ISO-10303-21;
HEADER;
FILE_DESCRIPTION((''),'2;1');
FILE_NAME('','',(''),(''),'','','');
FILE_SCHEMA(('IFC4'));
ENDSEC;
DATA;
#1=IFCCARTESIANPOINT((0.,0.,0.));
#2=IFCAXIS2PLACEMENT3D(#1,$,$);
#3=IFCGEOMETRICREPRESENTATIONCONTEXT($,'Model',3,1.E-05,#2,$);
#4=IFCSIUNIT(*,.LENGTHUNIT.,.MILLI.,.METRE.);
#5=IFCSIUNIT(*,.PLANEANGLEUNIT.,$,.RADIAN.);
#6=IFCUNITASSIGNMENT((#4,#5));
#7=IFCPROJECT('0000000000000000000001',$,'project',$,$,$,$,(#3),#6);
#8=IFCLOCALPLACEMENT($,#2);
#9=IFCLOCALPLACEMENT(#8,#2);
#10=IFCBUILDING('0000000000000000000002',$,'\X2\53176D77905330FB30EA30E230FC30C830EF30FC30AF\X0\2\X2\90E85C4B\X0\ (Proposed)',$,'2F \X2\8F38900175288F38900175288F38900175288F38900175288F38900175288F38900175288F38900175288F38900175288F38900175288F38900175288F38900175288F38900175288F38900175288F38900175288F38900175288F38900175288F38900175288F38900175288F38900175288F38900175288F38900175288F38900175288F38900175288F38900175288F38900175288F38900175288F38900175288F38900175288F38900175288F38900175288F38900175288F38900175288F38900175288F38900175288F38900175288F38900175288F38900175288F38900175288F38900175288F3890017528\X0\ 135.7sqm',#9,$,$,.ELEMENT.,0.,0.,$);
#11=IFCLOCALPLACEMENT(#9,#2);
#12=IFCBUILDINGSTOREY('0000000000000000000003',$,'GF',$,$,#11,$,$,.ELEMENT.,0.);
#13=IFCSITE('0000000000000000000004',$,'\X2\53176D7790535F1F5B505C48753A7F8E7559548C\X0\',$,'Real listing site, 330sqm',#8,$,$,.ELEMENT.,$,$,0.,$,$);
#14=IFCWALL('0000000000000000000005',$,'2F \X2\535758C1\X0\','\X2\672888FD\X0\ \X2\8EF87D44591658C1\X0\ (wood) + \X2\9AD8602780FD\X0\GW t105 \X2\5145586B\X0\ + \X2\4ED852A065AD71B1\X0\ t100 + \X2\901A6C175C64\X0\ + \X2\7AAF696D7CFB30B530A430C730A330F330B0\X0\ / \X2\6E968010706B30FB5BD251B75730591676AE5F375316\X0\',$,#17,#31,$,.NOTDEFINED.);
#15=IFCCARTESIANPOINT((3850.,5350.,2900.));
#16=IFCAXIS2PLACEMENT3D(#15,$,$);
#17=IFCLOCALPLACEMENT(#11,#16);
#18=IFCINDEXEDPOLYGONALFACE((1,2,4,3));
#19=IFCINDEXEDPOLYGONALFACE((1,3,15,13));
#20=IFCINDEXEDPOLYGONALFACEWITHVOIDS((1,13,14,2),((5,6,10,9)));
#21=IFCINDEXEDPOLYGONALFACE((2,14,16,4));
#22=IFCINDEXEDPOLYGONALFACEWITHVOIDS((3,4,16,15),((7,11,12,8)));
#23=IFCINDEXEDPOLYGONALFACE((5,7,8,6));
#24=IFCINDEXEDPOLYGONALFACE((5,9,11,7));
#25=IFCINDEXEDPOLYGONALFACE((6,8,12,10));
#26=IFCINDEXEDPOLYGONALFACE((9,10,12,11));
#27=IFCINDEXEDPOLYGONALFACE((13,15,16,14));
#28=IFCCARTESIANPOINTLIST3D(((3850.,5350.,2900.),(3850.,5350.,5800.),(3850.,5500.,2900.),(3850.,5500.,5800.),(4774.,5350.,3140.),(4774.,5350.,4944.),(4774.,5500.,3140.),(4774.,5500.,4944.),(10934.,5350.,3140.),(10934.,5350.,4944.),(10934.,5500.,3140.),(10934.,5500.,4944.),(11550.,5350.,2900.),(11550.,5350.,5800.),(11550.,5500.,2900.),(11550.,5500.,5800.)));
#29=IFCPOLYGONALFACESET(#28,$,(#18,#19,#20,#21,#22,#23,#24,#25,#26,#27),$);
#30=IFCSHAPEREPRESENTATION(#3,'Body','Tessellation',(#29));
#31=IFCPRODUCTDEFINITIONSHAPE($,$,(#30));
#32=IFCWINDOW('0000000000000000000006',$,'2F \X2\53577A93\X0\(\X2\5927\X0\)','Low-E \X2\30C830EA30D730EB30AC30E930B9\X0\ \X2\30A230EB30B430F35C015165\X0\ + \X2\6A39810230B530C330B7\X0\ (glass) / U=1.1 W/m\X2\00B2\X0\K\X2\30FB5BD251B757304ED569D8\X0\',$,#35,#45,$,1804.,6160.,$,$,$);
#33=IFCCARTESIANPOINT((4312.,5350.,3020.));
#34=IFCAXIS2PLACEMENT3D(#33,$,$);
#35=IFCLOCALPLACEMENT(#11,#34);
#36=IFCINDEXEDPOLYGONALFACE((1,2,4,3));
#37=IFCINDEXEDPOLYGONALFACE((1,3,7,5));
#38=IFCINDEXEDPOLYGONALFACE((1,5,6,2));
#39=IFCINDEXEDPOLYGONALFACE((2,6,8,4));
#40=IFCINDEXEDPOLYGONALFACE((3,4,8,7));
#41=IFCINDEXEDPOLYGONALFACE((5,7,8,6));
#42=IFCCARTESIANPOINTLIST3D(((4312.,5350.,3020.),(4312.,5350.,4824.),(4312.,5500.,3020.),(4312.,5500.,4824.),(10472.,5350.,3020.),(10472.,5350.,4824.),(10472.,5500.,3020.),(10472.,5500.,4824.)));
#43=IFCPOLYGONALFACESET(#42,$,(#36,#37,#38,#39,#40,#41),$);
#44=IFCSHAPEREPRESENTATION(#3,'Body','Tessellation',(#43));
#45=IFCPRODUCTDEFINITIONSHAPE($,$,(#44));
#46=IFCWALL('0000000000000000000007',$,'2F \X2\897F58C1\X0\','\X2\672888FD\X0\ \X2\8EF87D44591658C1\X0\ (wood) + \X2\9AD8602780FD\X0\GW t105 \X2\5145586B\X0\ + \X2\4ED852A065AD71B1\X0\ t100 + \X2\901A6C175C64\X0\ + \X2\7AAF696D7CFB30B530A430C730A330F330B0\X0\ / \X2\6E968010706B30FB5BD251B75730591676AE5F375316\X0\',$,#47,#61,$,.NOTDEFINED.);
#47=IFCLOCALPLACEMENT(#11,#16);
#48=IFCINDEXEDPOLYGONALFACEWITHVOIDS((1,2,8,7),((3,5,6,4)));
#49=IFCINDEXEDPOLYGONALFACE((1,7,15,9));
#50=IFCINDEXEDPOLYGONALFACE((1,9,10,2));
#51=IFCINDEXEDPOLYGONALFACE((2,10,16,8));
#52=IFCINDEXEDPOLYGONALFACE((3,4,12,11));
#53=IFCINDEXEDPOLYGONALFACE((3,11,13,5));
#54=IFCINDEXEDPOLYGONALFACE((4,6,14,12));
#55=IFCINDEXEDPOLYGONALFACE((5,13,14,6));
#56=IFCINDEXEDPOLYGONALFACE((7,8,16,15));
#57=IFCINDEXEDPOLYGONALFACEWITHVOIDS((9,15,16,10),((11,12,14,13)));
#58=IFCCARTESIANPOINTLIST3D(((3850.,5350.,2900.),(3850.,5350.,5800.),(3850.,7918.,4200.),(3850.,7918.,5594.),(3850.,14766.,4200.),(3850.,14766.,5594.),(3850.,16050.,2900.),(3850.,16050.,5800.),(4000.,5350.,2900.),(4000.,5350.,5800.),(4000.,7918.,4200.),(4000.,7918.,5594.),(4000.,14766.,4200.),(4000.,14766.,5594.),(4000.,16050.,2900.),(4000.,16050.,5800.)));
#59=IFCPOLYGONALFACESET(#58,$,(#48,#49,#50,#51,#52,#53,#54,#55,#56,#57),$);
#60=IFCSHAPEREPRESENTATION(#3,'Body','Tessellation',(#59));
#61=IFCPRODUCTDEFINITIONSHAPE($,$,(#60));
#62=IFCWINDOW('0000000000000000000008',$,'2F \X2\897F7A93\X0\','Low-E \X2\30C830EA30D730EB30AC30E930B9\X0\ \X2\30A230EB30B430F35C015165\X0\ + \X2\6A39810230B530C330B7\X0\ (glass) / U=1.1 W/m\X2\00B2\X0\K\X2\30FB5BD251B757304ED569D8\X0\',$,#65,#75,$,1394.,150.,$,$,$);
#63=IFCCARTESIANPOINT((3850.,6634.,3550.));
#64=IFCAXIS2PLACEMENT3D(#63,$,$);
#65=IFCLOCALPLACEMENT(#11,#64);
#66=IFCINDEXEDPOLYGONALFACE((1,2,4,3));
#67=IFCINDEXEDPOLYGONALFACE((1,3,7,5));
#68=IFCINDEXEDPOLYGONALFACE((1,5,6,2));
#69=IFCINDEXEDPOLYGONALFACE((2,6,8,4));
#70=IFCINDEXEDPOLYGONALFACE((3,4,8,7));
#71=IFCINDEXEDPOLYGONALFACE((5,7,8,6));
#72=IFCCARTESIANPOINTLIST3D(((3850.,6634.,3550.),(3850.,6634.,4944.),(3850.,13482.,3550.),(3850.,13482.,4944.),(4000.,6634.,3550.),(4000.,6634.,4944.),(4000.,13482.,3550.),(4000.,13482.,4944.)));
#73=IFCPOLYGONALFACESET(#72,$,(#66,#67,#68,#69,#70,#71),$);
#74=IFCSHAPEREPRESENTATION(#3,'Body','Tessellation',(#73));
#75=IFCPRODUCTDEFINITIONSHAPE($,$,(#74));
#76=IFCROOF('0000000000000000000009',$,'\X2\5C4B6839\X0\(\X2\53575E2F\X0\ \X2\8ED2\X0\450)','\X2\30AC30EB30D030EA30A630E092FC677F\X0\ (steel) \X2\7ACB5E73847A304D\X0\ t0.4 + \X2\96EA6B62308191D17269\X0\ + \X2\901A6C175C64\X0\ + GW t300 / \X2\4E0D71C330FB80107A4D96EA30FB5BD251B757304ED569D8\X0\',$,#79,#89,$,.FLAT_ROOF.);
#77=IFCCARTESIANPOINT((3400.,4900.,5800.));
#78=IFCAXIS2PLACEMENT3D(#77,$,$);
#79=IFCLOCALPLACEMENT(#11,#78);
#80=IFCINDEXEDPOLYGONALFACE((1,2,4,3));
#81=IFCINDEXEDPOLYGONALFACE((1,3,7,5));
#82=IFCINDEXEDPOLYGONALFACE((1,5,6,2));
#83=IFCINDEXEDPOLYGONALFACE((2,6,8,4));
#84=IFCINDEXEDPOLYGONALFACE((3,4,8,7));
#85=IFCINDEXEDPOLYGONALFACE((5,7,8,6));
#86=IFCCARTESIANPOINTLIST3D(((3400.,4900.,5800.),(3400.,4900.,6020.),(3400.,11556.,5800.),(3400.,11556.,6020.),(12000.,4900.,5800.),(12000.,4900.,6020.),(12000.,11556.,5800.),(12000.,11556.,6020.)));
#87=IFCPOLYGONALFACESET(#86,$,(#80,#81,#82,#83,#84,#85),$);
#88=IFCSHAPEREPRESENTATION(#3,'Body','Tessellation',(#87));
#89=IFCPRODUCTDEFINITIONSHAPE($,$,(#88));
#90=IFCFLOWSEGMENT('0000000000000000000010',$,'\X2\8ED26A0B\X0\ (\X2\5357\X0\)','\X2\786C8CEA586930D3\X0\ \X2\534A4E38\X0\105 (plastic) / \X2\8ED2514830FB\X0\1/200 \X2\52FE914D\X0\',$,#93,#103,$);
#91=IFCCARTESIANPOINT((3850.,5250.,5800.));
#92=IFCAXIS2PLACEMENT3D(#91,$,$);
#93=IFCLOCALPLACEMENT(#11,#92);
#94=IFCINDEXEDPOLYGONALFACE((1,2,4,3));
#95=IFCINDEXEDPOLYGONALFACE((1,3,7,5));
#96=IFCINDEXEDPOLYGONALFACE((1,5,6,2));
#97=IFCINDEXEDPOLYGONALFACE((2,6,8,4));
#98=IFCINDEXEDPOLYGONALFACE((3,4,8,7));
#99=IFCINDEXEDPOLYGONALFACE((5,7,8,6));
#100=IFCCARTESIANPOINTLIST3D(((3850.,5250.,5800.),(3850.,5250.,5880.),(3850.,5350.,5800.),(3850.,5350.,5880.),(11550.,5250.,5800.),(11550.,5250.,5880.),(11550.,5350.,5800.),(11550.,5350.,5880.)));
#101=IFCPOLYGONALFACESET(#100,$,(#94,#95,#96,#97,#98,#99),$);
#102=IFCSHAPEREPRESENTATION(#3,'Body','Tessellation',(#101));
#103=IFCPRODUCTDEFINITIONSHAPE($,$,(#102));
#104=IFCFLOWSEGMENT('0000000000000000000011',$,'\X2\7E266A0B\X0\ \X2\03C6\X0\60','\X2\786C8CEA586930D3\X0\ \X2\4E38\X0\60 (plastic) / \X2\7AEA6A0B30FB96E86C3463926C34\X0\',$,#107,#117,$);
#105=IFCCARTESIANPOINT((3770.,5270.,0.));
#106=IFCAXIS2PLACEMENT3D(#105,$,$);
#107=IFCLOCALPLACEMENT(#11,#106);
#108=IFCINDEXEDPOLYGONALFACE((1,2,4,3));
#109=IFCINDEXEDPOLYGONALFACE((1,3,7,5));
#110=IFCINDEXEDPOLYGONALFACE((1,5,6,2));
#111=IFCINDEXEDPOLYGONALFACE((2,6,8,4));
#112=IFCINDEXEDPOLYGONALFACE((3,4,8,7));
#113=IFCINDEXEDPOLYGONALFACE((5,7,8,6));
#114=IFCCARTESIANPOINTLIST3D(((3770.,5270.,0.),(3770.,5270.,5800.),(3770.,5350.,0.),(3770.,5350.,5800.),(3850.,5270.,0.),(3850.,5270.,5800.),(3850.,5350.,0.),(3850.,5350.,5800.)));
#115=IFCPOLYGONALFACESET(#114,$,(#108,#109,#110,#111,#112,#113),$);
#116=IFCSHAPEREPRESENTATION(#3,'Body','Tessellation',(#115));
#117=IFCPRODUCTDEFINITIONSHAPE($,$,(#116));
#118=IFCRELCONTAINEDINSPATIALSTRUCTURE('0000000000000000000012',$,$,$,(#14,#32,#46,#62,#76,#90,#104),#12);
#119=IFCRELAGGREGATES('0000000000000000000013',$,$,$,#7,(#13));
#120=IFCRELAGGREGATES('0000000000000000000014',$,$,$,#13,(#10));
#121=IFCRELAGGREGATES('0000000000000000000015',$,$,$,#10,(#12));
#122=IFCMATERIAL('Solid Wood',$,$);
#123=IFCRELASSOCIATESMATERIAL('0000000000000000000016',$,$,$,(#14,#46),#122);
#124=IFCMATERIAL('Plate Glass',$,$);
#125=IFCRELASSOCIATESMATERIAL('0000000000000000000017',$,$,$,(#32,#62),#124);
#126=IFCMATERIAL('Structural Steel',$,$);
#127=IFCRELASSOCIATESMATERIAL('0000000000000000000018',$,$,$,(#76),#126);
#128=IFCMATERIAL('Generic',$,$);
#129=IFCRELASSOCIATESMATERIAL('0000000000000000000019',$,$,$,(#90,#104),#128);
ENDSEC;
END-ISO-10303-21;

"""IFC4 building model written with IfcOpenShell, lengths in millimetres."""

from ifc_helpers import new_model, si_unit, frame, frame_2d, origin, place, context, project, spatial, rectangle, extrude, material, element, fill, save


model = new_model("IFC4")

# Units and contexts
model_context = context("Model", 3, precision=1e-05, world=origin())
ifc_project = project(units=[si_unit("LENGTHUNIT", "METRE", prefix="MILLI"), si_unit("PLANEANGLEUNIT", "RADIAN")], contexts=[model_context])

# Site, building, storey
site_placement = place(None, origin())
site = spatial("IfcSite", under=ifc_project, at=site_placement, Name="北海道弟子屈町美留和", ObjectType="Real listing site, 330sqm", CompositionType="ELEMENT", RefElevation=0.0)
building_placement = place(site_placement, origin())
building = spatial("IfcBuilding", under=site, at=building_placement, Name="北海道・リモートワーク2部屋 (Proposed)", ObjectType="2F 輸送用輸送用輸送用輸送用輸送用輸送用輸送用輸送用輸送用輸送用輸送用輸送用輸送用輸送用輸送用輸送用輸送用輸送用輸送用輸送用輸送用輸送用輸送用輸送用輸送用輸送用輸送用輸送用輸送用輸送用輸送用輸送用輸送用輸送用輸送用輸送用輸送用輸送用輸送用輸送用 135.7sqm", CompositionType="ELEMENT", ElevationOfRefHeight=0.0, ElevationOfTerrain=0.0)
storey_placement = place(building_placement, origin())
storey = spatial("IfcBuildingStorey", under=building, at=storey_placement, Name="GF", CompositionType="ELEMENT", Elevation=0.0)

# Shared definitions
ifc_material_1 = material(Name="Solid Wood")

# Shared definitions
ifc_material_2 = material(Name="Plate Glass")

# Walls, openings, windows
wall_1_placement = place(storey_placement, frame((3850.0, 5350.0, 2900.0)))
wall_1 = element("IfcWall", 1, at=wall_1_placement, inside=storey, material=ifc_material_1, Name="2F 南壁", Description="木製 軸組外壁 (wood) + 高性能GW t105 充填 + 付加断熱 t100 + 通気層 + 窯業系サイディング / 準耐火・寒冷地外皮強化", PredefinedType="NOTDEFINED", context=model_context, shape_type="SweptSolid", body=[
    extrude(rectangle(XDim=7700.0, YDim=150.0, at=frame_2d((3850.0, 75.0))), frame((3850.0, 5350.0, 2900.0)), (0.0, 0.0, 1.0), 2900.0),
])
opening_1_placement = place(storey_placement, frame((4312.0, 5350.0, 3020.0)))
opening_1 = element("IfcOpeningElement", 2, at=opening_1_placement, cuts=wall_1, PredefinedType="NOTDEFINED", context=model_context, shape_type="SweptSolid", body=[
    extrude(rectangle(XDim=6160.0, YDim=150.0, at=frame_2d((3080.0, 75.0))), frame((4312.0, 5350.0, 3020.0)), (0.0, 0.0, 1.0), 1804.0),
])
window_1_placement = place(storey_placement, frame((4312.0, 5350.0, 3020.0)))
window_1 = element("IfcWindow", 3, at=window_1_placement, inside=storey, material=ifc_material_2, Name="2F 南窓(大)", Description="Low-E トリプルガラス アルゴン封入 + 樹脂サッシ (glass) / U=1.1 W/m²K・寒冷地仕様", OverallHeight=1804.0, OverallWidth=6160.0, context=model_context, shape_type="SweptSolid", body=[
    extrude(rectangle(XDim=6160.0, YDim=150.0, at=frame_2d((3080.0, 75.0))), frame((4312.0, 5350.0, 3020.0)), (0.0, 0.0, 1.0), 1804.0),
])
fill(opening_1, window_1)
wall_2_placement = place(storey_placement, frame((3850.0, 5350.0, 2900.0)))
wall_2 = element("IfcWall", 4, at=wall_2_placement, inside=storey, material=ifc_material_1, Name="2F 西壁", Description="木製 軸組外壁 (wood) + 高性能GW t105 充填 + 付加断熱 t100 + 通気層 + 窯業系サイディング / 準耐火・寒冷地外皮強化", PredefinedType="NOTDEFINED", context=model_context, shape_type="SweptSolid", body=[
    extrude(rectangle(XDim=150.0, YDim=10700.0, at=frame_2d((75.0, 5350.0))), frame((3850.0, 5350.0, 2900.0)), (0.0, 0.0, 1.0), 2900.0),
])
opening_2_placement = place(storey_placement, frame((3850.0, 6634.0, 3550.0)))
opening_2 = element("IfcOpeningElement", 5, at=opening_2_placement, cuts=wall_2, PredefinedType="NOTDEFINED", context=model_context, shape_type="SweptSolid", body=[
    extrude(rectangle(XDim=150.0, YDim=6848.0, at=frame_2d((75.0, 3424.0))), frame((3850.0, 6634.0, 3550.0)), (0.0, 0.0, 1.0), 1394.0),
])
window_2_placement = place(storey_placement, frame((3850.0, 6634.0, 3550.0)))
window_2 = element("IfcWindow", 6, at=window_2_placement, inside=storey, material=ifc_material_2, Name="2F 西窓", Description="Low-E トリプルガラス アルゴン封入 + 樹脂サッシ (glass) / U=1.1 W/m²K・寒冷地仕様", OverallHeight=1394.0, OverallWidth=150.0, context=model_context, shape_type="SweptSolid", body=[
    extrude(rectangle(XDim=150.0, YDim=6848.0, at=frame_2d((75.0, 3424.0))), frame((3850.0, 6634.0, 3550.0)), (0.0, 0.0, 1.0), 1394.0),
])
fill(opening_2, window_2)

# Roof
ifc_material_3 = material(Name="Structural Steel")
for number, where, name in (
    (7, (3400.0, 4900.0, 5800.0), "屋根(南帯 軒450)"),
):
    element("IfcRoof", number, at=place(storey_placement, frame(where)), inside=storey, material=ifc_material_3, Name=name, Description="ガルバリウム鋼板 (steel) 立平葺き t0.4 + 雪止め金物 + 通気層 + GW t300 / 不燃・耐積雪・寒冷地仕様", PredefinedType="FLAT_ROOF", context=model_context, shape_type="SweptSolid", body=[
        extrude(rectangle(XDim=8600.0, YDim=6656.0, at=frame_2d((4300.0, 3328.0))), frame((3400.0, 4900.0, 5800.0)), (0.0, 0.0, 1.0), 220.0),
    ])

# Flow segments
ifc_material_4 = material(Name="Generic")
flow_segment_1_placement = place(storey_placement, frame((3850.0, 5250.0, 5800.0)))
element("IfcFlowSegment", 8, at=flow_segment_1_placement, inside=storey, material=ifc_material_4, Name="軒樋 (南)", Description="硬質塩ビ 半丸105 (plastic) / 軒先・1/200 勾配", context=model_context, shape_type="SweptSolid", body=[
    extrude(rectangle(XDim=7700.0, YDim=100.0, at=frame_2d((3850.0, 50.0))), frame((3850.0, 5250.0, 5800.0)), (0.0, 0.0, 1.0), 80.0),
])
flow_segment_2_placement = place(storey_placement, frame((3770.0, 5270.0, 0.0)))
element("IfcFlowSegment", 9, at=flow_segment_2_placement, inside=storey, material=ifc_material_4, Name="縦樋 φ60", Description="硬質塩ビ 丸60 (plastic) / 竪樋・雨水排水", context=model_context, shape_type="SweptSolid", body=[
    extrude(rectangle(XDim=80.0, YDim=80.0, at=frame_2d((40.0, 40.0))), frame((3770.0, 5270.0, 0.0)), (0.0, 0.0, 1.0), 5800.0),
])

save(model, "model.ifc")
